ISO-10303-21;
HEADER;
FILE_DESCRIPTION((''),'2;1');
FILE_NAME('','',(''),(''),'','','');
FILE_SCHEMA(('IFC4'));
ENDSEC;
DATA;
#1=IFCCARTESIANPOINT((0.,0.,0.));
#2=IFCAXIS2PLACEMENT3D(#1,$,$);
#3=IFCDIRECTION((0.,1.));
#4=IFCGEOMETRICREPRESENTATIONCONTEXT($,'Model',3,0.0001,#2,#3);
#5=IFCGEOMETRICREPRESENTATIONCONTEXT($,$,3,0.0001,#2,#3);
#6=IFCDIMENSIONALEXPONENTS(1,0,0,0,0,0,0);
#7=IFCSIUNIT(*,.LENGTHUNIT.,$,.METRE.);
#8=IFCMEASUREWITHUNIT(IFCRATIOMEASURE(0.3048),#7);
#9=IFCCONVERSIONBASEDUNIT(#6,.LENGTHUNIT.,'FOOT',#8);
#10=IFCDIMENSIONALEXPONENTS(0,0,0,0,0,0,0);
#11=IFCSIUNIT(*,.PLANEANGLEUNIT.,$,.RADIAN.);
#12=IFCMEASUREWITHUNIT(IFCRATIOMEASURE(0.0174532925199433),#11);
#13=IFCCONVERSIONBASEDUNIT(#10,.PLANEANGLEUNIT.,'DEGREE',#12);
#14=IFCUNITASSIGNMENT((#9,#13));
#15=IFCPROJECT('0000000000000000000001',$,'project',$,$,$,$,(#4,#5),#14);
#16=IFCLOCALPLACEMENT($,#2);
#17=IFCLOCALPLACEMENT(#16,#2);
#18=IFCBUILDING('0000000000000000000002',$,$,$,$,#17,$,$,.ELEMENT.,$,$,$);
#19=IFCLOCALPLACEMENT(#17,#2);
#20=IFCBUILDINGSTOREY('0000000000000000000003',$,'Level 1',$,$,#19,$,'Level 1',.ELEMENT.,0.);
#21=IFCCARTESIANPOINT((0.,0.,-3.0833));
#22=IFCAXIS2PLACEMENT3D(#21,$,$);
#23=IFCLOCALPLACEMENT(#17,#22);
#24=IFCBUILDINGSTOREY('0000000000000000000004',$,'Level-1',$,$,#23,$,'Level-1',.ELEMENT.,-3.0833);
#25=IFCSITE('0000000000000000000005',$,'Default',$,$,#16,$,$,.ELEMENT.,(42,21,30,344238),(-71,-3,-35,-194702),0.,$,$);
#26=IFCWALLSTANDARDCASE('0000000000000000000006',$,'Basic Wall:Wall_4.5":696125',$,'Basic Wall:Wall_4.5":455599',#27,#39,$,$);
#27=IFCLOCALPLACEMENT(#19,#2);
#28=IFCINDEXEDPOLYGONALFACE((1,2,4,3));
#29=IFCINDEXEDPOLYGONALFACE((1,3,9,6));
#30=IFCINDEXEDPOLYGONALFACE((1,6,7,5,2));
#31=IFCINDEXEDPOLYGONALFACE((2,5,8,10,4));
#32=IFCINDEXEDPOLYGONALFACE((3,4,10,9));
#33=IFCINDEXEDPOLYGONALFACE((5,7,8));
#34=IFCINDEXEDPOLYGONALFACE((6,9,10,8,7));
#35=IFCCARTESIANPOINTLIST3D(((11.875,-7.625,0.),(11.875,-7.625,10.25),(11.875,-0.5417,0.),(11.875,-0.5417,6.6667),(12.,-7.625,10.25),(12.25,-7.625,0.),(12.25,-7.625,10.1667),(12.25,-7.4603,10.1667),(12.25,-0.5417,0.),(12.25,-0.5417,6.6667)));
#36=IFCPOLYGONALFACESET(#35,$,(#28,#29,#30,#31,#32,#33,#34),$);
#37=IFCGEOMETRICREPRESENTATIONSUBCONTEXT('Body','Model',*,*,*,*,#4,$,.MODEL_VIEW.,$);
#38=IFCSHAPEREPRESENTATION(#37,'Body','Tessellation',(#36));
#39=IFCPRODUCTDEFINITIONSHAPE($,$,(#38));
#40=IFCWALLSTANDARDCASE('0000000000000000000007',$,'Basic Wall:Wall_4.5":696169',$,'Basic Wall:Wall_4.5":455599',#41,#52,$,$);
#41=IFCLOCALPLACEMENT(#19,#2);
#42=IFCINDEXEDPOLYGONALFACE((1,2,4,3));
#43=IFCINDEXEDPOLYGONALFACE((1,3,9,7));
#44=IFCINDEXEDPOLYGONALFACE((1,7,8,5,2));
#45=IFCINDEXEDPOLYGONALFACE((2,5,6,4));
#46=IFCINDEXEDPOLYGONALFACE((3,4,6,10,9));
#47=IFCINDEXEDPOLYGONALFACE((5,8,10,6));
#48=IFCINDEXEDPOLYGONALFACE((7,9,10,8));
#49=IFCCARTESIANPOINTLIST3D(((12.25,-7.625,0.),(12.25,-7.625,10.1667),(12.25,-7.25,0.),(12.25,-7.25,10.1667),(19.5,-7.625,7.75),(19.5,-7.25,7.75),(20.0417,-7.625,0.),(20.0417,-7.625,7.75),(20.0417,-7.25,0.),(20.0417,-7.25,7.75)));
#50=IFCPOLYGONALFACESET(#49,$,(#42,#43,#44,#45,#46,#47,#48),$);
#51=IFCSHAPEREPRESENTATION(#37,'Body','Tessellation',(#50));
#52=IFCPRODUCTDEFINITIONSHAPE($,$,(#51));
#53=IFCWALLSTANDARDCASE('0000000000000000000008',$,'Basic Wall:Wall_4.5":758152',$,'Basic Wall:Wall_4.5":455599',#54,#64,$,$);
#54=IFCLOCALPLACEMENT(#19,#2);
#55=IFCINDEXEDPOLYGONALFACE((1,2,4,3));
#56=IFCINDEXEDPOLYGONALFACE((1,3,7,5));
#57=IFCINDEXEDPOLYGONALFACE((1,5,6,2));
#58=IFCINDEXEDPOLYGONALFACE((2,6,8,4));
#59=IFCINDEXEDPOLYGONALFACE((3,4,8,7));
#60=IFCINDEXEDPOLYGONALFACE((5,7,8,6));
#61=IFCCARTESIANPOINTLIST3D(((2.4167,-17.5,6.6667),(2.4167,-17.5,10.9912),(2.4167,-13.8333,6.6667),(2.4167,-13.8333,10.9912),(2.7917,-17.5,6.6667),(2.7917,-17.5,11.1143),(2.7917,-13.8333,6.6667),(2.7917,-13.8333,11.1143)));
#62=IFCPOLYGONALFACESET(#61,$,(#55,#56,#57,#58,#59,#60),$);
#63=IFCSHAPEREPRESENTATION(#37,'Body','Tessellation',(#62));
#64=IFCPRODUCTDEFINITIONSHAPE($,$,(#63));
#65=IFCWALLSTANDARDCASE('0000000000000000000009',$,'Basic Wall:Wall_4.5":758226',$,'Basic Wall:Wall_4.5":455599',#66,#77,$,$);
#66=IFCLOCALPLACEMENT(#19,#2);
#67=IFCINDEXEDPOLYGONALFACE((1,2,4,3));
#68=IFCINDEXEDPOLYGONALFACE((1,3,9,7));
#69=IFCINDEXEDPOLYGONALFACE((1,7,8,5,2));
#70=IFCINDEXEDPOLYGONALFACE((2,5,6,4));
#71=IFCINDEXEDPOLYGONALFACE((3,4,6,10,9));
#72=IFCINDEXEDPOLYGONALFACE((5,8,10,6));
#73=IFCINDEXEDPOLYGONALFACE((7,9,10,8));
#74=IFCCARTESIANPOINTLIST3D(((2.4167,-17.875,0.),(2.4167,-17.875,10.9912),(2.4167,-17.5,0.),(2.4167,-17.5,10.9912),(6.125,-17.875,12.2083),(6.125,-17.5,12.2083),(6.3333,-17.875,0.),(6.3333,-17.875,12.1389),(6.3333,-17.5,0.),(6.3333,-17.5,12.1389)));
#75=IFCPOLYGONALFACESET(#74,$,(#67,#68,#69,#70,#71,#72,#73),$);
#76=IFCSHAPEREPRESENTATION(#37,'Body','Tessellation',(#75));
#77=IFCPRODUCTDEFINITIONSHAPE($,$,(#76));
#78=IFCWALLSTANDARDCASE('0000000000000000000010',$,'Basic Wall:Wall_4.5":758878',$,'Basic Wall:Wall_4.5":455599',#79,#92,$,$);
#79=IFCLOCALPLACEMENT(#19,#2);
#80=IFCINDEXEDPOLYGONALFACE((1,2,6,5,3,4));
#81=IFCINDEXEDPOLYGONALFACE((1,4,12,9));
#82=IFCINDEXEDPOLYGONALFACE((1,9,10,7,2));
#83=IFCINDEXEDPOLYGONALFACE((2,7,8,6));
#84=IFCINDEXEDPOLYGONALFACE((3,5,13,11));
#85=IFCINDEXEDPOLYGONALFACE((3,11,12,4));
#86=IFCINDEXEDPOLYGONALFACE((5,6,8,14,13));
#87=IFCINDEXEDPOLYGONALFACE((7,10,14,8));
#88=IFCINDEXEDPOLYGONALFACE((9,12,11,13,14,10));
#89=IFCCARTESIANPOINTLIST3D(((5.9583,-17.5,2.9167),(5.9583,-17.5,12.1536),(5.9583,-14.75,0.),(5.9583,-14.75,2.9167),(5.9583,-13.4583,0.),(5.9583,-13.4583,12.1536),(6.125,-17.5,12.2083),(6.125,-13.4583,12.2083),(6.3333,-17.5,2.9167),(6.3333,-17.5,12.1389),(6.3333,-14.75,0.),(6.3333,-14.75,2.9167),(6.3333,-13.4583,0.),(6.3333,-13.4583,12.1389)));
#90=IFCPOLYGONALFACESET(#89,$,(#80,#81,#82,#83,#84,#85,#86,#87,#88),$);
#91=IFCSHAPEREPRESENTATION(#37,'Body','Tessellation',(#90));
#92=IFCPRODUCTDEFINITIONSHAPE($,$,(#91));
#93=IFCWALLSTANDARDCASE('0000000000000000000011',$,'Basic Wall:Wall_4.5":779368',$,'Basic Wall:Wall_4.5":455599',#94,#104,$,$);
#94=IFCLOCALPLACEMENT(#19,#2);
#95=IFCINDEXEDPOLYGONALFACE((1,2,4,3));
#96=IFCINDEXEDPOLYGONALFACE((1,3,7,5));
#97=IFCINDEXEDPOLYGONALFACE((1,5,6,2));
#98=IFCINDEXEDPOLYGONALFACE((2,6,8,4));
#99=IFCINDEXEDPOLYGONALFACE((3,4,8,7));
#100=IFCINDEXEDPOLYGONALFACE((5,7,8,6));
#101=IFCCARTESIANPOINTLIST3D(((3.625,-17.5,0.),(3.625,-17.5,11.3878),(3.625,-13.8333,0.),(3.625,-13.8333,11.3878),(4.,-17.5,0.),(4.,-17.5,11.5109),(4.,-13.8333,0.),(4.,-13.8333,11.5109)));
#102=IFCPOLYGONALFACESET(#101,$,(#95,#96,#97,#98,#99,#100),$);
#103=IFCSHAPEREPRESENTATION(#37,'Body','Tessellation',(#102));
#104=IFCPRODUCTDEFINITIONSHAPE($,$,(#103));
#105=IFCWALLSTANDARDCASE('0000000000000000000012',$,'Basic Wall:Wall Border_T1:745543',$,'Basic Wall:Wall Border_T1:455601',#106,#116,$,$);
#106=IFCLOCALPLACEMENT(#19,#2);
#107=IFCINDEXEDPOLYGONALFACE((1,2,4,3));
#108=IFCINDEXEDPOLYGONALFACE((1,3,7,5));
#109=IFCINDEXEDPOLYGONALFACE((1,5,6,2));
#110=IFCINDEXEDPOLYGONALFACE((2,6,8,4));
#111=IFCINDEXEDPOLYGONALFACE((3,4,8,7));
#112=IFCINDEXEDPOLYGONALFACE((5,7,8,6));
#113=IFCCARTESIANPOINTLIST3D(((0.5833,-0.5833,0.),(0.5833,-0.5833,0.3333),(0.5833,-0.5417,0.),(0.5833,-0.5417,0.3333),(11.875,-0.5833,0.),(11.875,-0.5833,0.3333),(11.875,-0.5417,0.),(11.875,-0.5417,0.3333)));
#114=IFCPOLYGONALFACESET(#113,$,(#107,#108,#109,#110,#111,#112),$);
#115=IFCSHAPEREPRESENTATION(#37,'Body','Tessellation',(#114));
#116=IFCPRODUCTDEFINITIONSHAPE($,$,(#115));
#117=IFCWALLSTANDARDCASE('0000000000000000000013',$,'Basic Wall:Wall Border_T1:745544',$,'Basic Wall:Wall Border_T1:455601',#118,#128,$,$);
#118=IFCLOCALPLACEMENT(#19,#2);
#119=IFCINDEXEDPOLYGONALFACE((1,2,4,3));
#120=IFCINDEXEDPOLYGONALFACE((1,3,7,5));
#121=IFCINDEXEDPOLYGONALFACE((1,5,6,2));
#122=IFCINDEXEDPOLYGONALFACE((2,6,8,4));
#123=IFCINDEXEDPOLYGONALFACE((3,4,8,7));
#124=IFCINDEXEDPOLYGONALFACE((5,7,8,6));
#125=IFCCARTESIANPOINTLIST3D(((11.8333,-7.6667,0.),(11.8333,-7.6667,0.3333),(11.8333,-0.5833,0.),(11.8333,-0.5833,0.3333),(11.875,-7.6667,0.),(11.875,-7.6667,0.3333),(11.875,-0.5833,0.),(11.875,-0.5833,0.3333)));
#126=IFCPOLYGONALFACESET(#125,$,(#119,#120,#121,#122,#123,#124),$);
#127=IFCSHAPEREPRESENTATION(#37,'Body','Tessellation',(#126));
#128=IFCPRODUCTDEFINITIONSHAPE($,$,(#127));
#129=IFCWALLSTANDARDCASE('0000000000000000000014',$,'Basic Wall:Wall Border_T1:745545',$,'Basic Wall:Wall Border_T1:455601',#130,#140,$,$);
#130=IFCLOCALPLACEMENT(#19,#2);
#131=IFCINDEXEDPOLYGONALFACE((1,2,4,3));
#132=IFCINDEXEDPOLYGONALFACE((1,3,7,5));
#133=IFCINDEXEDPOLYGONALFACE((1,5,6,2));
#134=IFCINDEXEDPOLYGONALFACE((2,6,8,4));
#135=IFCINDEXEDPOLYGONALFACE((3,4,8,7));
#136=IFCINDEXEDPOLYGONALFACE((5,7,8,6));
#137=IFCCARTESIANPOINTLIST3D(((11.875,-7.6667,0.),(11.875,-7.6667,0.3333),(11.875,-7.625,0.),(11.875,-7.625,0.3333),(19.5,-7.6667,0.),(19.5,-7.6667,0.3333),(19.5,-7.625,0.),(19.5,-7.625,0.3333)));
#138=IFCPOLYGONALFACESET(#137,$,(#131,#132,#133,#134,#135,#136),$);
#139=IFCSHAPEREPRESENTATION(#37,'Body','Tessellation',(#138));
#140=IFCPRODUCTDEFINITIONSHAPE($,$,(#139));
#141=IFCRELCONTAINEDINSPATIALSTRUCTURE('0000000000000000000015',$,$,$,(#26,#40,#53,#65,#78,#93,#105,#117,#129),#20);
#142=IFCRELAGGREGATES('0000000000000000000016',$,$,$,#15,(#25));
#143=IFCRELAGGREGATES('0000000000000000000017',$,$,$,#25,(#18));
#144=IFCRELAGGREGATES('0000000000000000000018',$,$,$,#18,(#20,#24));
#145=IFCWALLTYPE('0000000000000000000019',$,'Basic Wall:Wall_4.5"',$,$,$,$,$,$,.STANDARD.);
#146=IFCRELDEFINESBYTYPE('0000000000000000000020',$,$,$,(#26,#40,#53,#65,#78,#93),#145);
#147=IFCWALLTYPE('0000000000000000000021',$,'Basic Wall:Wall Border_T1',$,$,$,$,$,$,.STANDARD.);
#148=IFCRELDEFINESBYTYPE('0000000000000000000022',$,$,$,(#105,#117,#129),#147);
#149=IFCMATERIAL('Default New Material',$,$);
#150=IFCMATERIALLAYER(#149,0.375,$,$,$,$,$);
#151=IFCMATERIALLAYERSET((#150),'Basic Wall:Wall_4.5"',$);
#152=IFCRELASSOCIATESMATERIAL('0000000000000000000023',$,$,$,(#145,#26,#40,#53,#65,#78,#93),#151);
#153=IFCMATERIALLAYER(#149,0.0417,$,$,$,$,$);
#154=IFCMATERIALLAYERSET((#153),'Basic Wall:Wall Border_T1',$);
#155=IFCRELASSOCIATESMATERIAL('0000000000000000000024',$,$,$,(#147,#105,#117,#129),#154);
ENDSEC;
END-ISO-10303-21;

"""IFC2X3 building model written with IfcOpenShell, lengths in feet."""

from ifc_helpers import new_model, entity, si_unit, converted_unit, direction, frame, frame_2d, origin, place, context, subcontext, project, spatial, polyline, rectangle, extrude, clip, bounded_halfspace, material, layer, layer_set, layer_usage, type_object, element, save


model = new_model("IFC2X3")

# Units and contexts
model_context = context("Model", 3, precision=0.0001, world=origin(), true_north=direction((0.0, 1.0)))
context_of_model = context(None, 3, precision=0.0001, world=origin(), true_north=direction((0.0, 1.0)))
body_context = subcontext(model_context, "Body", "Model", "MODEL_VIEW")
ifc_project = project(units=[converted_unit("LENGTHUNIT", "FOOT", entity("IfcRatioMeasure", 0.3048), si_unit("LENGTHUNIT", "METRE"), dimensions=[1, 0, 0, 0, 0, 0, 0]), converted_unit("PLANEANGLEUNIT", "DEGREE", entity("IfcRatioMeasure", 0.0174532925199433), si_unit("PLANEANGLEUNIT", "RADIAN"), dimensions=[0, 0, 0, 0, 0, 0, 0])], contexts=[model_context, context_of_model])

# Site, building, storey
site_placement = place(None, origin())
site = spatial("IfcSite", under=ifc_project, at=site_placement, Name="Default", CompositionType="ELEMENT", RefLatitude=(42, 21, 30, 344238), RefLongitude=(-71, -3, -35, -194702), RefElevation=0.0)
building_placement = place(site_placement, origin())
building = spatial("IfcBuilding", under=site, at=building_placement, CompositionType="ELEMENT")
storey_1_placement = place(building_placement, origin())
storey_1 = spatial("IfcBuildingStorey", under=building, at=storey_1_placement, Name="Level 1", LongName="Level 1", CompositionType="ELEMENT", Elevation=0.0)

# Shared definitions
ifc_material_1 = material(Name="Default New Material")

# Shared definitions
storey_2_placement = place(building_placement, frame((0.0, 0.0, -3.0833)))
storey_2 = spatial("IfcBuildingStorey", under=building, at=storey_2_placement, Name="Level-1", LongName="Level-1", CompositionType="ELEMENT", Elevation=-3.0833)

# Walls
ifc_layer_1 = layer(ifc_material_1, 0.375)
ifc_layer_set_1 = layer_set([ifc_layer_1], Name="Basic Wall:Wall_4.5\"")
ifc_layer_usage_1 = layer_usage(ifc_layer_set_1, "AXIS2", "NEGATIVE", 0.1875)
wall_type_1 = type_object("IfcWallType", Name="Basic Wall:Wall_4.5\"", PredefinedType="STANDARD", material=ifc_layer_set_1)
wall_1_placement = place(storey_1_placement, frame((12.0625, -0.5417, 0.0), z_axis=(0.0, 0.0, 1.0), x_axis=(0.0, -1.0, 0.0)))
element("IfcWallStandardCase", 1, at=wall_1_placement, inside=storey_1, type_object=wall_type_1, material=ifc_layer_usage_1, Name="Basic Wall:Wall_4.5\":696125", ObjectType="Basic Wall:Wall_4.5\":455599", context=body_context, shape_type="Clipping", body=[
    clip(clip(extrude(rectangle(XDim=7.0833, YDim=0.375, at=frame_2d((3.5417, 0.0), x_axis=(-1.0, 0.0))), origin(), (0.0, 0.0, 1.0), 10.25), bounded_halfspace(frame((7.0833, -0.0625, 10.25), z_axis=(0.0, -0.316228, -0.948683), x_axis=(1.0, 0.0, 0.0)), True, frame((7.0833, -0.0625, 10.25)), polyline([(0.0, 0.0), (0.0, 0.25), (-0.1647, 0.25), (0.0, 0.0)]))), bounded_halfspace(frame((0.0, -0.1875, 6.6667), z_axis=(0.451408, 0.0, -0.892318), x_axis=(0.0, 1.0, 0.0)), True, frame((0.0, -0.1875, 6.6667)), polyline([(0.0, 0.0), (7.0833, 0.0), (7.0833, 0.125), (6.9186, 0.375), (0.0, 0.375), (0.0, 0.0)]))),
])
ifc_layer_usage_2 = layer_usage(ifc_layer_set_1, "AXIS2", "NEGATIVE", 0.1875)
wall_2_placement = place(storey_1_placement, frame((12.25, -7.4375, 0.0)))
element("IfcWallStandardCase", 2, at=wall_2_placement, inside=storey_1, type_object=wall_type_1, material=ifc_layer_usage_2, Name="Basic Wall:Wall_4.5\":696169", ObjectType="Basic Wall:Wall_4.5\":455599", context=body_context, shape_type="Clipping", body=[
    clip(clip(extrude(rectangle(XDim=7.7917, YDim=0.375, at=frame_2d((3.8958, 0.0), x_axis=(-1.0, 0.0))), origin(), (0.0, 0.0, 1.0), 10.1667), bounded_halfspace(frame((0.0, -0.1875, 10.1667), z_axis=(-0.316228, 0.0, -0.948683), x_axis=(0.0, -1.0, 0.0)), True, frame((0.0, -0.1875, 10.1667)), polyline([(0.0, 0.0), (7.25, 0.0), (7.25, 0.375), (0.0, 0.375), (0.0, 0.1647), (0.0, 0.0)]))), bounded_halfspace(frame((7.25, -0.1875, 7.75), z_axis=(0.0, 0.0, -1.0), x_axis=(0.0, -1.0, 0.0)), True, frame((7.25, -0.1875, 7.75)), polyline([(0.0, 0.0), (0.5417, 0.0), (0.5417, 0.375), (0.0, 0.375), (0.0, 0.0)]))),
])

# Walls, openings
ifc_layer_usage_3 = layer_usage(ifc_layer_set_1, "AXIS2", "NEGATIVE", 0.1875)
wall_3_placement = place(storey_1_placement, frame((2.6042, -13.8333, 6.6667), z_axis=(0.0, 0.0, 1.0), x_axis=(0.0, -1.0, 0.0)))
wall_3 = element("IfcWallStandardCase", 3, at=wall_3_placement, inside=storey_1, type_object=wall_type_1, material=ifc_layer_usage_3, Name="Basic Wall:Wall_4.5\":758152", ObjectType="Basic Wall:Wall_4.5\":455599", context=body_context, shape_type="Clipping", body=[
    clip(extrude(rectangle(XDim=3.6667, YDim=0.375, at=frame_2d((1.8333, 0.0), x_axis=(-1.0, 0.0))), origin(), (0.0, 0.0, 1.0), 4.4476), bounded_halfspace(frame((0.0, -0.1875, 4.3245), z_axis=(0.0, 0.311853, -0.95013), x_axis=(1.0, 0.0, 0.0)), True, frame((0.0, -0.1875, 4.3245)), polyline([(0.0, 0.0), (3.6667, 0.0), (3.6667, 0.375), (0.0, 0.375), (0.0, 0.0)]))),
])
opening_1_placement = place(wall_3_placement, frame((3.6667, -5.1875, -6.6667), z_axis=(0.0, 0.0, 1.0), x_axis=(0.0, 1.0, 0.0)))
element("IfcOpeningElement", 4, at=opening_1_placement, cuts=wall_3, ObjectType="Opening", context=body_context, shape_type="SweptSolid", body=[
    extrude(rectangle(XDim=6.6667, YDim=3.6667, at=frame_2d((0.0, 0.0), x_axis=(1.0, 0.0))), frame((0.0, 1.8333, 3.3333), z_axis=(1.0, 0.0, 0.0), x_axis=(0.0, 0.0, 1.0)), (0.0, 0.0, 1.0), 10.0),
])
ifc_layer_usage_4 = layer_usage(ifc_layer_set_1, "AXIS2", "NEGATIVE", 0.1875)
wall_4_placement = place(storey_1_placement, frame((2.4167, -17.6875, 0.0)))
wall_4 = element("IfcWallStandardCase", 5, at=wall_4_placement, inside=storey_1, type_object=wall_type_1, material=ifc_layer_usage_4, Name="Basic Wall:Wall_4.5\":758226", ObjectType="Basic Wall:Wall_4.5\":455599", context=body_context, shape_type="Clipping", body=[
    clip(clip(extrude(rectangle(XDim=3.9167, YDim=0.375, at=frame_2d((1.9583, 0.0), x_axis=(-1.0, 0.0))), origin(), (0.0, 0.0, 1.0), 12.2083), bounded_halfspace(frame((3.7083, -0.1875, 12.2083), z_axis=(-0.316228, 0.0, -0.948683), x_axis=(0.0, -1.0, 0.0)), True, frame((3.7083, -0.1875, 12.2083)), polyline([(0.0, 0.0), (0.2083, 0.0), (0.2083, 0.375), (0.0, 0.375), (0.0, 0.0)]))), bounded_halfspace(frame((0.0, -0.1875, 10.9912), z_axis=(0.311853, 0.0, -0.95013), x_axis=(0.0, -1.0, 0.0)), True, frame((0.0, -0.1875, 10.9912)), polyline([(0.0, 0.0), (3.7083, 0.0), (3.7083, 0.375), (3.5417, 0.375), (1.5833, 0.375), (1.2083, 0.375), (0.375, 0.375), (0.0, 0.375), (0.0, 0.0)]))),
])
opening_2_placement = place(wall_4_placement, frame((0.0, 0.1875, 0.0)))
element("IfcOpeningElement", 6, at=opening_2_placement, cuts=wall_4, ObjectType="Opening", context=body_context, shape_type="SweptSolid", body=[
    extrude(rectangle(XDim=6.6667, YDim=0.375, at=frame_2d((0.0, 0.0), x_axis=(0.0, 1.0))), frame((0.1875, 0.0, 3.3333), z_axis=(0.0, 1.0, 0.0), x_axis=(1.0, 0.0, 0.0)), (0.0, 0.0, 1.0), 3.6667),
])
ifc_layer_usage_5 = layer_usage(ifc_layer_set_1, "AXIS2", "POSITIVE", -0.1875)
wall_5_placement = place(storey_1_placement, frame((6.1458, -17.5, 0.0), z_axis=(0.0, 0.0, 1.0), x_axis=(0.0, 1.0, 0.0)))
wall_5 = element("IfcWallStandardCase", 7, at=wall_5_placement, inside=storey_1, type_object=wall_type_1, material=ifc_layer_usage_5, Name="Basic Wall:Wall_4.5\":758878", ObjectType="Basic Wall:Wall_4.5\":455599", context=body_context, shape_type="Clipping", body=[
    clip(clip(extrude(rectangle(XDim=4.0417, YDim=0.375, at=frame_2d((2.0208, 0.0), x_axis=(-1.0, 0.0))), origin(), (0.0, 0.0, 1.0), 12.2083), bounded_halfspace(frame((0.0, -0.1875, 12.1389), z_axis=(0.0, 0.316228, -0.948683), x_axis=(-1.0, 0.0, 0.0)), True, frame((0.0, -0.1875, 12.1389)), polyline([(0.0, 0.0), (4.0417, 0.0), (4.0417, 0.2083), (0.0, 0.2083), (0.0, 0.0)]))), bounded_halfspace(frame((4.0417, 0.1875, 12.1536), z_axis=(0.0, -0.311853, -0.95013), x_axis=(-1.0, 0.0, 0.0)), True, frame((4.0417, 0.1875, 12.1536)), polyline([(0.0, 0.0), (-0.375, 0.0), (-4.0417, 0.0), (-4.0417, -0.1667), (0.0, -0.1667), (0.0, 0.0)]))),
])
opening_3_placement = place(wall_5_placement, frame((-0.0833, 4.8125, 0.0)))
element("IfcOpeningElement", 8, at=opening_3_placement, cuts=wall_5, ObjectType="Opening", context=body_context, shape_type="SweptSolid", body=[
    extrude(rectangle(XDim=2.9167, YDim=2.8333, at=frame_2d((0.0, 0.0), x_axis=(1.0, 0.0))), frame((1.4167, -10.0, 1.4583), z_axis=(0.0, 1.0, 0.0), x_axis=(0.0, 0.0, -1.0)), (0.0, 0.0, 1.0), 10.0),
])

# Walls
ifc_layer_usage_6 = layer_usage(ifc_layer_set_1, "AXIS2", "NEGATIVE", 0.1875)
wall_6_placement = place(storey_1_placement, frame((3.8125, -13.8333, 0.0), z_axis=(0.0, 0.0, 1.0), x_axis=(0.0, -1.0, 0.0)))
element("IfcWallStandardCase", 9, at=wall_6_placement, inside=storey_1, type_object=wall_type_1, material=ifc_layer_usage_6, Name="Basic Wall:Wall_4.5\":779368", ObjectType="Basic Wall:Wall_4.5\":455599", context=body_context, shape_type="Clipping", body=[
    clip(extrude(rectangle(XDim=3.6667, YDim=0.375, at=frame_2d((1.8333, 0.0), x_axis=(-1.0, 0.0))), origin(), (0.0, 0.0, 1.0), 11.5109), bounded_halfspace(frame((0.0, -0.1875, 11.3878), z_axis=(0.0, 0.311853, -0.95013), x_axis=(1.0, 0.0, 0.0)), True, frame((0.0, -0.1875, 11.3878)), polyline([(0.0, 0.0), (3.6667, 0.0), (3.6667, 0.375), (0.0, 0.375), (0.0, 0.0)]))),
])
ifc_layer_2 = layer(ifc_material_1, 0.0417)
ifc_layer_set_2 = layer_set([ifc_layer_2], Name="Basic Wall:Wall Border_T1")
ifc_layer_usage_7 = layer_usage(ifc_layer_set_2, "AXIS2", "POSITIVE", -0.0208)
wall_type_2 = type_object("IfcWallType", Name="Basic Wall:Wall Border_T1", PredefinedType="STANDARD", material=ifc_layer_set_2)
wall_7_placement = place(storey_1_placement, frame((0.5833, -0.5625, 0.0)))
element("IfcWallStandardCase", 10, at=wall_7_placement, inside=storey_1, type_object=wall_type_2, material=ifc_layer_usage_7, Name="Basic Wall:Wall Border_T1:745543", ObjectType="Basic Wall:Wall Border_T1:455601", context=body_context, shape_type="SweptSolid", body=[
    extrude(rectangle(XDim=11.2917, YDim=0.0417, at=frame_2d((5.6458, 0.0), x_axis=(-1.0, 0.0))), origin(), (0.0, 0.0, 1.0), 0.3333),
])
ifc_layer_usage_8 = layer_usage(ifc_layer_set_2, "AXIS2", "POSITIVE", -0.0208)
wall_8_placement = place(storey_1_placement, frame((11.8542, -0.5833, 0.0), z_axis=(0.0, 0.0, 1.0), x_axis=(0.0, -1.0, 0.0)))
element("IfcWallStandardCase", 11, at=wall_8_placement, inside=storey_1, type_object=wall_type_2, material=ifc_layer_usage_8, Name="Basic Wall:Wall Border_T1:745544", ObjectType="Basic Wall:Wall Border_T1:455601", context=body_context, shape_type="SweptSolid", body=[
    extrude(rectangle(XDim=7.0833, YDim=0.0417, at=frame_2d((3.5417, 0.0), x_axis=(-1.0, 0.0))), origin(), (0.0, 0.0, 1.0), 0.3333),
])
ifc_layer_usage_9 = layer_usage(ifc_layer_set_2, "AXIS2", "POSITIVE", -0.0208)
wall_9_placement = place(storey_1_placement, frame((11.875, -7.6458, 0.0)))
element("IfcWallStandardCase", 12, at=wall_9_placement, inside=storey_1, type_object=wall_type_2, material=ifc_layer_usage_9, Name="Basic Wall:Wall Border_T1:745545", ObjectType="Basic Wall:Wall Border_T1:455601", context=body_context, shape_type="SweptSolid", body=[
    extrude(rectangle(XDim=7.625, YDim=0.0417, at=frame_2d((3.8125, 0.0), x_axis=(-1.0, 0.0))), origin(), (0.0, 0.0, 1.0), 0.3333),
])

save(model, "model.ifc")
